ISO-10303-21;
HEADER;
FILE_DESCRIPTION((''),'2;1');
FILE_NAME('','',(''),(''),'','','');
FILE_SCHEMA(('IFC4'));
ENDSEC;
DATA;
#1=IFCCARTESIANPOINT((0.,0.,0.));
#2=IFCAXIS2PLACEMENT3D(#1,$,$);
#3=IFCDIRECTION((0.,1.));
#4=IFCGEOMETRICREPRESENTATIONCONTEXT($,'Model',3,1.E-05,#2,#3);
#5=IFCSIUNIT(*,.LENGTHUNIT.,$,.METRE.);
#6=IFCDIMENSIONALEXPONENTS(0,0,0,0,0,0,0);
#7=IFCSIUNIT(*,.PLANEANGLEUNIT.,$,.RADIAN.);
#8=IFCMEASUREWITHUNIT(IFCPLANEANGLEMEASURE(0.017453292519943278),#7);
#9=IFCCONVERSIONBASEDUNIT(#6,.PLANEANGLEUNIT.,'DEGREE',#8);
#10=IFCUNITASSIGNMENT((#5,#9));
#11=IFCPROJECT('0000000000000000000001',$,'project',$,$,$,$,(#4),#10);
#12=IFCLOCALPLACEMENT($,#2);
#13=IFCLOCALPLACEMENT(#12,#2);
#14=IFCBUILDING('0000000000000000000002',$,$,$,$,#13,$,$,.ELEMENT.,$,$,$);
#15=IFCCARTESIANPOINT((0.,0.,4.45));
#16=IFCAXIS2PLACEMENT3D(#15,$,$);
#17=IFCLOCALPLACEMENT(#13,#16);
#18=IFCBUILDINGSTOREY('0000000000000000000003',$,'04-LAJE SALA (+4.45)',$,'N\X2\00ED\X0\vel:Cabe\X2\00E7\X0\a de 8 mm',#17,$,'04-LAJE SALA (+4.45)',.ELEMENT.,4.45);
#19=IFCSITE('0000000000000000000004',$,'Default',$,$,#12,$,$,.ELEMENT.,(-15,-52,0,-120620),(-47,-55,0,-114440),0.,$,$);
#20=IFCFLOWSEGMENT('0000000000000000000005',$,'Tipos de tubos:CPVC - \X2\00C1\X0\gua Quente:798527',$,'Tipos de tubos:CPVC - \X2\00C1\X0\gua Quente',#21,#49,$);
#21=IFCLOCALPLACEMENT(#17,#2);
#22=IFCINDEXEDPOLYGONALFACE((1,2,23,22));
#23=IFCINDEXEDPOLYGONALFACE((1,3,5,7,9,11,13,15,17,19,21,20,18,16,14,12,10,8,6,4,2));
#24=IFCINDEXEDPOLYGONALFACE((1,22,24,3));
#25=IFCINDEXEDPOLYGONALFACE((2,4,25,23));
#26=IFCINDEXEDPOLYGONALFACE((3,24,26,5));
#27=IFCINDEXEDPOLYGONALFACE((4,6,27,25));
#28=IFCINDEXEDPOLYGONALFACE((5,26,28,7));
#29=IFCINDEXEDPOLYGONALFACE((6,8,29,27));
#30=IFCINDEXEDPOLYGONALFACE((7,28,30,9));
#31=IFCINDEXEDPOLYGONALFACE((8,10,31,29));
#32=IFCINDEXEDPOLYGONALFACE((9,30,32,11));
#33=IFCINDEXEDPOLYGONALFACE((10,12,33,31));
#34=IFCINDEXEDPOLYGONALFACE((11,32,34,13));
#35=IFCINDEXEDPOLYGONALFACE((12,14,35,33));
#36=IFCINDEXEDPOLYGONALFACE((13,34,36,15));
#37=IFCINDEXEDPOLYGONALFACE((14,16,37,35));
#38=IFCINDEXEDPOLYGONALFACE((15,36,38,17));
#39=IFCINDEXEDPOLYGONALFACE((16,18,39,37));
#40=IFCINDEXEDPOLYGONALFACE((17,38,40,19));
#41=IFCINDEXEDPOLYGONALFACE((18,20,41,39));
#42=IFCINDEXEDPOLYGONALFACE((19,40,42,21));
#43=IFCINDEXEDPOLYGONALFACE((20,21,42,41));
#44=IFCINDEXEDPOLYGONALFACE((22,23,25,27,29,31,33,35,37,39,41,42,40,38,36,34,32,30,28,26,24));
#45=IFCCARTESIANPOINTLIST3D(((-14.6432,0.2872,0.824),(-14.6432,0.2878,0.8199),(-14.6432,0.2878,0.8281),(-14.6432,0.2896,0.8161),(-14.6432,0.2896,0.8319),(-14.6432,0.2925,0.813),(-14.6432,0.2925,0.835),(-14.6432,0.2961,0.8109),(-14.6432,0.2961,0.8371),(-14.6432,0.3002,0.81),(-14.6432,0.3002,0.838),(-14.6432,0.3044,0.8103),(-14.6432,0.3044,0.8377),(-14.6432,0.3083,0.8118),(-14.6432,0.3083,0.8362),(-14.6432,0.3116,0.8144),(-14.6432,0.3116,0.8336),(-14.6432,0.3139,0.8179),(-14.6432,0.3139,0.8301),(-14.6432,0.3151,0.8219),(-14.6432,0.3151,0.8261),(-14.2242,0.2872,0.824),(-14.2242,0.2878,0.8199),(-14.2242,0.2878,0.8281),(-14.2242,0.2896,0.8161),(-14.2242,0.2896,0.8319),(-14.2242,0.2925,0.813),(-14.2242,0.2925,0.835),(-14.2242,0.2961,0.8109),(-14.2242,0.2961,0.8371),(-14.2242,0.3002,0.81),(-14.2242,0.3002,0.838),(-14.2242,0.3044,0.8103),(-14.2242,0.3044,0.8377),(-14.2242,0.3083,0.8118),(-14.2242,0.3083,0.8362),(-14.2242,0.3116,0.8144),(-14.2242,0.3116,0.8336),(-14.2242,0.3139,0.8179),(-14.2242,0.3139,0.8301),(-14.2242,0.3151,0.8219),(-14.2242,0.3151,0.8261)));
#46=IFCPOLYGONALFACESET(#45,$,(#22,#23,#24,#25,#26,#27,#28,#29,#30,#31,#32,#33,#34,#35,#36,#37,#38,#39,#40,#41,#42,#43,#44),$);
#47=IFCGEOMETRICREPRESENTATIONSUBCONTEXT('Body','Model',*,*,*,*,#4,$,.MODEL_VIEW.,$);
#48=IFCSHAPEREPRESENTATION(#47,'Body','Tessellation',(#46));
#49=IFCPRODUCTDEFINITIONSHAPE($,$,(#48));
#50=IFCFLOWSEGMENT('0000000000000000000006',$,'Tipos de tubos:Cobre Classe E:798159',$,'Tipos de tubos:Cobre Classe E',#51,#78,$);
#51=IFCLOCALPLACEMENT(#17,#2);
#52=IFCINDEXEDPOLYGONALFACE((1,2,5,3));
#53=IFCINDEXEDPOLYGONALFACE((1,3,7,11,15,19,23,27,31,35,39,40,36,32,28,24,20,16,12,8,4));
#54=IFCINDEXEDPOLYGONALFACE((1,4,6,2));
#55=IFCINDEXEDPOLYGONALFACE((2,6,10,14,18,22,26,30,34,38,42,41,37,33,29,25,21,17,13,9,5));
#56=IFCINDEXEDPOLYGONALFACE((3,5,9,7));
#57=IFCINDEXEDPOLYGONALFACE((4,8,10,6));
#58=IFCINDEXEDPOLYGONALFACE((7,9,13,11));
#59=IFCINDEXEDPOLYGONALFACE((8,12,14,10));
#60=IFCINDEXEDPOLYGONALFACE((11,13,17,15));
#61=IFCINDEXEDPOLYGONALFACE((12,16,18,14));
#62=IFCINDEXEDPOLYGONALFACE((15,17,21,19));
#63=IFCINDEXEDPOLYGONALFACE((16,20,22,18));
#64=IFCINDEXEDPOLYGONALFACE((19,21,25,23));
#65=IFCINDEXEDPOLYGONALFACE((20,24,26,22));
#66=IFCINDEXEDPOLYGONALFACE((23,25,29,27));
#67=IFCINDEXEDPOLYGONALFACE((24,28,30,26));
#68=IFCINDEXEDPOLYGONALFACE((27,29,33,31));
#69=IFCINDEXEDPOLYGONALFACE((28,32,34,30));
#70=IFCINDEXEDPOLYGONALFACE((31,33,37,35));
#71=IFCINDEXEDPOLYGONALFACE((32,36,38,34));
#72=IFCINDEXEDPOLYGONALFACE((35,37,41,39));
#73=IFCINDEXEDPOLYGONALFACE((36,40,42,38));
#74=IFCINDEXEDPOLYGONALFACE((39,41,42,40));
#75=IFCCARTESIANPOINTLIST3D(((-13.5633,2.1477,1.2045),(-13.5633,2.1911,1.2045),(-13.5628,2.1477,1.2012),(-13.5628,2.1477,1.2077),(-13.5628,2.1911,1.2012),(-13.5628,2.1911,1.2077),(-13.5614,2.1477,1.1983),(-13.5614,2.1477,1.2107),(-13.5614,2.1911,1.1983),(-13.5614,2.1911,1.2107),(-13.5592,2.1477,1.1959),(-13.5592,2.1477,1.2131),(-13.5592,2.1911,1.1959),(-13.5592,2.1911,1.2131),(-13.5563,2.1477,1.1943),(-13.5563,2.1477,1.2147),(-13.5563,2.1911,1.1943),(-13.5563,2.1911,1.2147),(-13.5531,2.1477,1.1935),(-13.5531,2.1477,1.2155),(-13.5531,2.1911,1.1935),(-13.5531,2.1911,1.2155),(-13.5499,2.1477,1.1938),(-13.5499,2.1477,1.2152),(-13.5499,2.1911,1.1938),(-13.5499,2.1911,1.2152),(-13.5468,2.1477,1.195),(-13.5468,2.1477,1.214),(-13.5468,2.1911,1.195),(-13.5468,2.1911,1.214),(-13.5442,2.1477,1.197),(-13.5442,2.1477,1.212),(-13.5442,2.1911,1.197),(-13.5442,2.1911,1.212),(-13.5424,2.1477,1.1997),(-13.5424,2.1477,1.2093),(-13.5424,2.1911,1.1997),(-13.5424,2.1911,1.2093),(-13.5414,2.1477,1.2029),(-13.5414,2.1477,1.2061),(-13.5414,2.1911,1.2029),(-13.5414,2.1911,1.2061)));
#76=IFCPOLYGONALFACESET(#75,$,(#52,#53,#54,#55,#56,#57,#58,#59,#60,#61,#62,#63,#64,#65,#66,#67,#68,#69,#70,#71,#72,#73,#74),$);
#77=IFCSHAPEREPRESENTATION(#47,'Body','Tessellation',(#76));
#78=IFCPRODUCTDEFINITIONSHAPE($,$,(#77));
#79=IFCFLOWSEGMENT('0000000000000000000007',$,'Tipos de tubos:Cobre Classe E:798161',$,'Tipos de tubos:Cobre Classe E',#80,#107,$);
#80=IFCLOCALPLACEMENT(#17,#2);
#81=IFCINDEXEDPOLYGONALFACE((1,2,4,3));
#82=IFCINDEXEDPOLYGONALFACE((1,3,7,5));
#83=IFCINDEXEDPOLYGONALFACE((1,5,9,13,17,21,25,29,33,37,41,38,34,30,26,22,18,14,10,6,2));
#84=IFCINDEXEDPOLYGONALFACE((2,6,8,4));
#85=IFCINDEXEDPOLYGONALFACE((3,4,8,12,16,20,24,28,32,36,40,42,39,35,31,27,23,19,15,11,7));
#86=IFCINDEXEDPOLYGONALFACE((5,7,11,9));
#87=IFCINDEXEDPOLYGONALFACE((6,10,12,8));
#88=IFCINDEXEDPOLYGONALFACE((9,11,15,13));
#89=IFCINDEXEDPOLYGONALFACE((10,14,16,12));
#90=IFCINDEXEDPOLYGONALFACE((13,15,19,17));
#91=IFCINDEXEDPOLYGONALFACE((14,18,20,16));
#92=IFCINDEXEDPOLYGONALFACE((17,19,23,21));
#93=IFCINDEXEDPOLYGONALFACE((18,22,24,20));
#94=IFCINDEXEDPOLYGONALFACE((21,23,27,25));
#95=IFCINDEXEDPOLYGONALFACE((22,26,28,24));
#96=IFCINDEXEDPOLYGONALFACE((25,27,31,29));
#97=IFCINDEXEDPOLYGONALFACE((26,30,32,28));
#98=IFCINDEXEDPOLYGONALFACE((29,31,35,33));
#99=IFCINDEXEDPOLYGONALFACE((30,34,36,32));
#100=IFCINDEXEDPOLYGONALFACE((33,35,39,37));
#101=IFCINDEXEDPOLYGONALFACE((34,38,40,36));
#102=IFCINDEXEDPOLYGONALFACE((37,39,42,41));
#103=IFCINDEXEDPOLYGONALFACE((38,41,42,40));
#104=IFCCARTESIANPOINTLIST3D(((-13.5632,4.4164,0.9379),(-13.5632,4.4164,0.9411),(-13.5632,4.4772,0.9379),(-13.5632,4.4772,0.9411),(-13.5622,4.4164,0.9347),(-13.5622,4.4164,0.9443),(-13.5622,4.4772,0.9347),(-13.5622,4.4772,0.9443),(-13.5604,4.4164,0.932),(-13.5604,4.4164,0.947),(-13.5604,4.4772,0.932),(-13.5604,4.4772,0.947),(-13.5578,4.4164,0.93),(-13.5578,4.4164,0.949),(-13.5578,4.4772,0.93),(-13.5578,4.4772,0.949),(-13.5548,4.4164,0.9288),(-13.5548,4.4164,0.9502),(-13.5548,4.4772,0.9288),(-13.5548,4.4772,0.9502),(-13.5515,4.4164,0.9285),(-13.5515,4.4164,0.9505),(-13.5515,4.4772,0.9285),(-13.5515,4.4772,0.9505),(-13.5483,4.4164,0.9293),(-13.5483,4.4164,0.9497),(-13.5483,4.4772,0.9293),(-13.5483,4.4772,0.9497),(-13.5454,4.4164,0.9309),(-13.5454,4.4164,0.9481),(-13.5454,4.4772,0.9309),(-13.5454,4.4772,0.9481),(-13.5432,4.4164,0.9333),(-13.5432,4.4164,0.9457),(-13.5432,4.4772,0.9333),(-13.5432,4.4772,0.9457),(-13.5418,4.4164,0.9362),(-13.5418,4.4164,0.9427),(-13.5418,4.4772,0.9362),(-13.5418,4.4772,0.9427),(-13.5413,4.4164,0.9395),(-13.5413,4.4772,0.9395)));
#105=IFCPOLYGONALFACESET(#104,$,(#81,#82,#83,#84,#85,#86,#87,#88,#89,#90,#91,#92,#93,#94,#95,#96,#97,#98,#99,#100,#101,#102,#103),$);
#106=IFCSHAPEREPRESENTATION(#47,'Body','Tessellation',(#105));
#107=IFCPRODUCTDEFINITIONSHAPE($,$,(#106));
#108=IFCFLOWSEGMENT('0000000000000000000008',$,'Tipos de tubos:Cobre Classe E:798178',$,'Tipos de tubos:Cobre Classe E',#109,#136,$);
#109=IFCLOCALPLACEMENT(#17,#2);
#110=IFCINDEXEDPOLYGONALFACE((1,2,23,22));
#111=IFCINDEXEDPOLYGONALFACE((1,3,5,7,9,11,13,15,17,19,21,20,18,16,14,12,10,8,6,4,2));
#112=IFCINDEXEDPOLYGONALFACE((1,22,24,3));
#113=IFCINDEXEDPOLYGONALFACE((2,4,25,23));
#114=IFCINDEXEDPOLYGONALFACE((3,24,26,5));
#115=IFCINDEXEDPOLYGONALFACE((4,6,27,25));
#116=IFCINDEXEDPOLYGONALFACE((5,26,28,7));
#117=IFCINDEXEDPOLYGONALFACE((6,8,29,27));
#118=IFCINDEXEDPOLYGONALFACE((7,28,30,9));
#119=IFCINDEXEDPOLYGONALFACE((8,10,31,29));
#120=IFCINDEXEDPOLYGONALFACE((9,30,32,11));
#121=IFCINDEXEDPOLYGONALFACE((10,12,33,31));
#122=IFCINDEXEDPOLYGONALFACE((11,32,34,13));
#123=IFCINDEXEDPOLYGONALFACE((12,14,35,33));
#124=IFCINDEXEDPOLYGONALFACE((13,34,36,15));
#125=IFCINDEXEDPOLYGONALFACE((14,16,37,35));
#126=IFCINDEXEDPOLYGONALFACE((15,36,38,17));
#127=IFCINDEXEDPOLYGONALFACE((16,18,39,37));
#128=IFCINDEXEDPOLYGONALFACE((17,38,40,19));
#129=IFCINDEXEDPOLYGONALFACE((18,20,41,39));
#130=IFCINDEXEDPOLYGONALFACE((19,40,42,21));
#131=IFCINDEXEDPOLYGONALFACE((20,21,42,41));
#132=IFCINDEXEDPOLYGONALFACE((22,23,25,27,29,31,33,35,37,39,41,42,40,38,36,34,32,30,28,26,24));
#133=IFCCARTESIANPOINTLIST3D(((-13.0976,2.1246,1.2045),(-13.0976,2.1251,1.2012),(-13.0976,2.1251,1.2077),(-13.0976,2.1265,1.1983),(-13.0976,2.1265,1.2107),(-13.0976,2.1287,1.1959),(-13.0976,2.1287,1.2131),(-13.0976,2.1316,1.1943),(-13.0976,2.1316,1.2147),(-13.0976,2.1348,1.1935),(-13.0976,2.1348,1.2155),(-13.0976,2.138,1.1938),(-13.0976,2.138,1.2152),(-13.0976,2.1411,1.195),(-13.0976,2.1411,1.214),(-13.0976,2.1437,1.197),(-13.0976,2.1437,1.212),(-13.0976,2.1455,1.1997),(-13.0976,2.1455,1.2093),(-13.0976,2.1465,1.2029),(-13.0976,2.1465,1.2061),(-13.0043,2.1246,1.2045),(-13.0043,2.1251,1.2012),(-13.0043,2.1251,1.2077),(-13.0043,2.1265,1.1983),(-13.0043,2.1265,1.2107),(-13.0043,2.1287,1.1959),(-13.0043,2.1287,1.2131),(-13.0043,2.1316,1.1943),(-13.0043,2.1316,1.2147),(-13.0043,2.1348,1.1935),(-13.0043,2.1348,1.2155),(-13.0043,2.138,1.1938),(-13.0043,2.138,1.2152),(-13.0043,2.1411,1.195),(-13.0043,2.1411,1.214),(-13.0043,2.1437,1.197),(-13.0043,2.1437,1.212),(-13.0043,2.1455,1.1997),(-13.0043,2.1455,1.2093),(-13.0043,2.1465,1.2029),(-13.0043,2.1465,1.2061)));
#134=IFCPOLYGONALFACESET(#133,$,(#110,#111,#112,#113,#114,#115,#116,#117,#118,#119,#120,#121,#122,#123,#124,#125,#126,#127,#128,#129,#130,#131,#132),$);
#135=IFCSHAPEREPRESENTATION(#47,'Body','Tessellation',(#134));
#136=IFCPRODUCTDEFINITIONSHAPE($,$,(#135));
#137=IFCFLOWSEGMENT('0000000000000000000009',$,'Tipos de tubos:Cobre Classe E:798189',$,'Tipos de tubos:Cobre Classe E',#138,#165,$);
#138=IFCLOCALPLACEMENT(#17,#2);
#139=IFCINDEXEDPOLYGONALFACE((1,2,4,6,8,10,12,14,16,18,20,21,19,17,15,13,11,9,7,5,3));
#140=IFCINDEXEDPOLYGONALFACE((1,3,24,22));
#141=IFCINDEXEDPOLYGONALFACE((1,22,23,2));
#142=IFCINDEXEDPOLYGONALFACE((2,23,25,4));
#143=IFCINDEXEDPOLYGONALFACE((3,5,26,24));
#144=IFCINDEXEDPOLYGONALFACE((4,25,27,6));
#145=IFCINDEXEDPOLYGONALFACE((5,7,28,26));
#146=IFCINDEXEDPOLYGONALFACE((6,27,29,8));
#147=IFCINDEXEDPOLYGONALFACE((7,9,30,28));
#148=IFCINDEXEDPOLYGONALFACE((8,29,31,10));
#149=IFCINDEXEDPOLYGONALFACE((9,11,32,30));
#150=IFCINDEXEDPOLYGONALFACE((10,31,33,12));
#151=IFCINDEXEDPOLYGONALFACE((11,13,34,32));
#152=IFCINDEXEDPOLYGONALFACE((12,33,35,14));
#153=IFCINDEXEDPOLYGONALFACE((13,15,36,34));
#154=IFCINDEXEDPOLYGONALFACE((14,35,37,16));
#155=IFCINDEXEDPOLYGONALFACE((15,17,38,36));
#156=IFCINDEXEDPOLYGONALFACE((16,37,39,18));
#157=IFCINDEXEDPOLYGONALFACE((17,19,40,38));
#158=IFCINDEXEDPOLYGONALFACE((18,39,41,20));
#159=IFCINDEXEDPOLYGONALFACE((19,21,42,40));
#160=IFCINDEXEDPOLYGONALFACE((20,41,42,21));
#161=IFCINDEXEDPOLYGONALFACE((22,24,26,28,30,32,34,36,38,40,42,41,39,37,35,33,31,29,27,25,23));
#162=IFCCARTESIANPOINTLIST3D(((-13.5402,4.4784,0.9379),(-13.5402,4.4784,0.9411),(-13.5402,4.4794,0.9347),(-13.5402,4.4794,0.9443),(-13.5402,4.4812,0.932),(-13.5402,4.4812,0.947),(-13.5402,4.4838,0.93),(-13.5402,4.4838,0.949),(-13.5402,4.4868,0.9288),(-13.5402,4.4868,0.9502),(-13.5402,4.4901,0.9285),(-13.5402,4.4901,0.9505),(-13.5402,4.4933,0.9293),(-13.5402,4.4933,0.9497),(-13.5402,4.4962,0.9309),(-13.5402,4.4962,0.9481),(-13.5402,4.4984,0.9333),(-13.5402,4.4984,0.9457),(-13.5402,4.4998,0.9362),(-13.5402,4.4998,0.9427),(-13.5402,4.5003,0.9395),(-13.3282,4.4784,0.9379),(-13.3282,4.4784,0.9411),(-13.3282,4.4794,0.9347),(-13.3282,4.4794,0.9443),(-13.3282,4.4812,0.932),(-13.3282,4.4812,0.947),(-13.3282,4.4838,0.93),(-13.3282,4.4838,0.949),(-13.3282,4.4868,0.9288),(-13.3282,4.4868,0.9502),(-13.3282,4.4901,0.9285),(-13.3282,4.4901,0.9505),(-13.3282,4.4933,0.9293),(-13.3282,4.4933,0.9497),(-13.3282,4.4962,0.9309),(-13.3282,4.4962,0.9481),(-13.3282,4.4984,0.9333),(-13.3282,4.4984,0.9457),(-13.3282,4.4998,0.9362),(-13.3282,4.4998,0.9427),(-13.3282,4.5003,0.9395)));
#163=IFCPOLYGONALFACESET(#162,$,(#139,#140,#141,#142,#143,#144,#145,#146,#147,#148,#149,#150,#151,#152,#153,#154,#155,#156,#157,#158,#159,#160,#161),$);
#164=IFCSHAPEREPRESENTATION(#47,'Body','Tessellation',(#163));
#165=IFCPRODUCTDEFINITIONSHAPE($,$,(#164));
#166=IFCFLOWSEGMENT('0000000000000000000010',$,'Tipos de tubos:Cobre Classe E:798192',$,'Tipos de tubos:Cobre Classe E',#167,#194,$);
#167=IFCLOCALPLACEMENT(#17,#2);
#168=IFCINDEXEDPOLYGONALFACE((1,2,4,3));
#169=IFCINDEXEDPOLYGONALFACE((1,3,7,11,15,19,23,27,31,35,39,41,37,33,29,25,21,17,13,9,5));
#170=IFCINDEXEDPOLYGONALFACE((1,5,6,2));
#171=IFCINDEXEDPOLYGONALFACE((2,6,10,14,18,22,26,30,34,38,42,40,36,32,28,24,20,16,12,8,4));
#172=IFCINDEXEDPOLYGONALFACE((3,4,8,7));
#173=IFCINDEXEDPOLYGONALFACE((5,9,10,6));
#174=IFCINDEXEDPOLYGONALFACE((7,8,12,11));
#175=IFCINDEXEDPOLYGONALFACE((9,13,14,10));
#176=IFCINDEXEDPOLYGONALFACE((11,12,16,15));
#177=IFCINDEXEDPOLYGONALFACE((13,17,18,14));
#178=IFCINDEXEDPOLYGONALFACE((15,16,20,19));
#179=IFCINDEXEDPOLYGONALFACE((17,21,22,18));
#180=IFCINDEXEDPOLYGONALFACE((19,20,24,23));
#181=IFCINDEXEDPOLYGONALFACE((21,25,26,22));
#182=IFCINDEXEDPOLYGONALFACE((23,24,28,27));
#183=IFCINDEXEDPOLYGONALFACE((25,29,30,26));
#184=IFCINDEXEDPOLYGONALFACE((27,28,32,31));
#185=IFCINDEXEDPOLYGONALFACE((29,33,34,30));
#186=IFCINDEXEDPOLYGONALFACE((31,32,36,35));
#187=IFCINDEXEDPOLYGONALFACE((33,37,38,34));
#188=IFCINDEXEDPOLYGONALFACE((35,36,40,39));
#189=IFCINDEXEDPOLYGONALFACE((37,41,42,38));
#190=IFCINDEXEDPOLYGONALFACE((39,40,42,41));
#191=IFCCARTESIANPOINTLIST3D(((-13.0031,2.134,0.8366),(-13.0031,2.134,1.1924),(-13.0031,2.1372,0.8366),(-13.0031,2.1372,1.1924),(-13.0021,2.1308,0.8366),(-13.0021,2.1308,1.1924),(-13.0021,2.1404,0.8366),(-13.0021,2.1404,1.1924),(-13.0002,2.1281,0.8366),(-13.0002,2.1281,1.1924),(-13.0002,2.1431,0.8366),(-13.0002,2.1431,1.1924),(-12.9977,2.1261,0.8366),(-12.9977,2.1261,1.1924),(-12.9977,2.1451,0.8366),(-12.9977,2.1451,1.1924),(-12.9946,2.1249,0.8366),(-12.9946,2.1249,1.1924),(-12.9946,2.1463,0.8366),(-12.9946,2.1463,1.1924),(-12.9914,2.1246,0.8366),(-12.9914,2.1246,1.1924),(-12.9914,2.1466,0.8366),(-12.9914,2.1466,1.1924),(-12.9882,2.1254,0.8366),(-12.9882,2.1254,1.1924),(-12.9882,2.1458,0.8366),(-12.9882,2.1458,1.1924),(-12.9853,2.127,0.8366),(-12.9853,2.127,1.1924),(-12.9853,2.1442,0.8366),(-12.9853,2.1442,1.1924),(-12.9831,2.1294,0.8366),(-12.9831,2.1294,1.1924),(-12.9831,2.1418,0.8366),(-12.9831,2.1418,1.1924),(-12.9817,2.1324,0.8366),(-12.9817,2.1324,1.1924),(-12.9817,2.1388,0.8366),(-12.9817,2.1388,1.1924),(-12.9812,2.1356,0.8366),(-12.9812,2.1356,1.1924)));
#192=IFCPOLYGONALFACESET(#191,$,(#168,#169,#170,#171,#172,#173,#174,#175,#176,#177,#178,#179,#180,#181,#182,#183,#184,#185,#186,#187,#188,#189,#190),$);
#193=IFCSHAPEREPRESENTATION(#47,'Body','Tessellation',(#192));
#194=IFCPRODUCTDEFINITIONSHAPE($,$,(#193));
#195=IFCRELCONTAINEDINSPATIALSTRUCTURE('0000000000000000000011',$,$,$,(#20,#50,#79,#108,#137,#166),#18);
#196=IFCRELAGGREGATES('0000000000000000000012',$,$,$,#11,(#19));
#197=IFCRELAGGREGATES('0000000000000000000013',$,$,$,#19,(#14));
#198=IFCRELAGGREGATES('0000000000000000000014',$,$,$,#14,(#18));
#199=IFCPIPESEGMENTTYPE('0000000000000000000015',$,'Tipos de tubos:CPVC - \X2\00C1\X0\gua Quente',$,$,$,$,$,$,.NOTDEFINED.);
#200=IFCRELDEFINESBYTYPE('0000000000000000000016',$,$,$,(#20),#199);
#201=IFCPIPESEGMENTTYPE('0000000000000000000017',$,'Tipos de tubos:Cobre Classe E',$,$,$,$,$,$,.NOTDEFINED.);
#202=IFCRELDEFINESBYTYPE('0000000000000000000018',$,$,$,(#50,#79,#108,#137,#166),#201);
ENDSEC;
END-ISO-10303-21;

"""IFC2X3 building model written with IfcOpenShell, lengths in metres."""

from ifc_helpers import new_model, entity, si_unit, converted_unit, direction, frame, frame_2d, origin, origin_2d_with_axis, place, context, subcontext, project, spatial, circle, extrude, type_object, element, save


model = new_model("IFC2X3")

# Units and contexts
model_context = context("Model", 3, precision=1e-05, world=origin(), true_north=direction((0.0, 1.0)))
body_context = subcontext(model_context, "Body", "Model", "MODEL_VIEW")
ifc_project = project(units=[si_unit("LENGTHUNIT", "METRE"), converted_unit("PLANEANGLEUNIT", "DEGREE", entity("IfcPlaneAngleMeasure", 0.017453292519943278), si_unit("PLANEANGLEUNIT", "RADIAN"), dimensions=[0, 0, 0, 0, 0, 0, 0])], contexts=[model_context])

# Site, building, storey
site_placement = place(None, origin())
site = spatial("IfcSite", under=ifc_project, at=site_placement, Name="Default", CompositionType="ELEMENT", RefLatitude=(-15, -52, 0, -120620), RefLongitude=(-47, -55, 0, -114440), RefElevation=0.0)
building_placement = place(site_placement, origin())
building = spatial("IfcBuilding", under=site, at=building_placement, CompositionType="ELEMENT")
storey_placement = place(building_placement, frame((0.0, 0.0, 4.45)))
storey = spatial("IfcBuildingStorey", under=building, at=storey_placement, Name="04-LAJE SALA (+4.45)", ObjectType="Nível:Cabeça de 8 mm", LongName="04-LAJE SALA (+4.45)", CompositionType="ELEMENT", Elevation=4.45)

# Flow segments
pipe_segment_type_1 = type_object("IfcPipeSegmentType", Name="Tipos de tubos:CPVC - Água Quente", PredefinedType="NOTDEFINED")
flow_segment_1_placement = place(storey_placement, origin())
element("IfcFlowSegment", 1, at=flow_segment_1_placement, inside=storey, type_object=pipe_segment_type_1, Name="Tipos de tubos:CPVC - Água Quente:798527", ObjectType="Tipos de tubos:CPVC - Água Quente", context=body_context, shape_type="SweptSolid", body=[
    extrude(circle(Radius=0.0141, at=frame_2d((0.0, 0.0), x_axis=(1.0, 0.0))), frame((-14.6432, 0.3013, 0.824), z_axis=(1.0, 0.0, 0.0), x_axis=(0.0, -1.0, 0.0)), (0.0, 0.0, 1.0), 0.419),
])
pipe_segment_type_2 = type_object("IfcPipeSegmentType", Name="Tipos de tubos:Cobre Classe E", PredefinedType="NOTDEFINED")
flow_segment_2_placement = place(storey_placement, origin())
element("IfcFlowSegment", 2, at=flow_segment_2_placement, inside=storey, type_object=pipe_segment_type_2, Name="Tipos de tubos:Cobre Classe E:798159", ObjectType="Tipos de tubos:Cobre Classe E", context=body_context, shape_type="SweptSolid", body=[
    extrude(circle(Radius=0.011, at=origin_2d_with_axis()), frame((-13.5523, 2.1477, 1.2045), z_axis=(0.0, 1.0, 0.0), x_axis=(-1.0, 0.0, 0.0)), (0.0, 0.0, 1.0), 0.0434),
])
flow_segment_3_placement = place(storey_placement, origin())
element("IfcFlowSegment", 3, at=flow_segment_3_placement, inside=storey, type_object=pipe_segment_type_2, Name="Tipos de tubos:Cobre Classe E:798161", ObjectType="Tipos de tubos:Cobre Classe E", context=body_context, shape_type="SweptSolid", body=[
    extrude(circle(Radius=0.011, at=frame_2d((0.0, 0.0), x_axis=(1.0, 0.0))), frame((-13.5523, 4.4164, 0.9395), z_axis=(0.0, 1.0, 0.0), x_axis=(1.0, 0.0, 0.0)), (0.0, 0.0, 1.0), 0.0608),
])
flow_segment_4_placement = place(storey_placement, origin())
element("IfcFlowSegment", 4, at=flow_segment_4_placement, inside=storey, type_object=pipe_segment_type_2, Name="Tipos de tubos:Cobre Classe E:798178", ObjectType="Tipos de tubos:Cobre Classe E", context=body_context, shape_type="SweptSolid", body=[
    extrude(circle(Radius=0.011, at=origin_2d_with_axis()), frame((-13.0976, 2.1356, 1.2045), z_axis=(1.0, 0.0, 0.0), x_axis=(0.0, -1.0, 0.0)), (0.0, 0.0, 1.0), 0.0933),
])
flow_segment_5_placement = place(storey_placement, origin())
element("IfcFlowSegment", 5, at=flow_segment_5_placement, inside=storey, type_object=pipe_segment_type_2, Name="Tipos de tubos:Cobre Classe E:798189", ObjectType="Tipos de tubos:Cobre Classe E", context=body_context, shape_type="SweptSolid", body=[
    extrude(circle(Radius=0.011, at=frame_2d((0.0, 0.0), x_axis=(1.0, 0.0))), frame((-13.5402, 4.4893, 0.9395), z_axis=(1.0, 0.0, 0.0), x_axis=(0.0, 1.0, 0.0)), (0.0, 0.0, 1.0), 0.212),
])
flow_segment_6_placement = place(storey_placement, origin())
element("IfcFlowSegment", 6, at=flow_segment_6_placement, inside=storey, type_object=pipe_segment_type_2, Name="Tipos de tubos:Cobre Classe E:798192", ObjectType="Tipos de tubos:Cobre Classe E", context=body_context, shape_type="SweptSolid", body=[
    extrude(circle(Radius=0.011, at=frame_2d((0.0, 0.0), x_axis=(1.0, 0.0))), frame((-12.9922, 2.1356, 0.8366)), (0.0, 0.0, 1.0), 0.3558),
])

save(model, "model.ifc")
